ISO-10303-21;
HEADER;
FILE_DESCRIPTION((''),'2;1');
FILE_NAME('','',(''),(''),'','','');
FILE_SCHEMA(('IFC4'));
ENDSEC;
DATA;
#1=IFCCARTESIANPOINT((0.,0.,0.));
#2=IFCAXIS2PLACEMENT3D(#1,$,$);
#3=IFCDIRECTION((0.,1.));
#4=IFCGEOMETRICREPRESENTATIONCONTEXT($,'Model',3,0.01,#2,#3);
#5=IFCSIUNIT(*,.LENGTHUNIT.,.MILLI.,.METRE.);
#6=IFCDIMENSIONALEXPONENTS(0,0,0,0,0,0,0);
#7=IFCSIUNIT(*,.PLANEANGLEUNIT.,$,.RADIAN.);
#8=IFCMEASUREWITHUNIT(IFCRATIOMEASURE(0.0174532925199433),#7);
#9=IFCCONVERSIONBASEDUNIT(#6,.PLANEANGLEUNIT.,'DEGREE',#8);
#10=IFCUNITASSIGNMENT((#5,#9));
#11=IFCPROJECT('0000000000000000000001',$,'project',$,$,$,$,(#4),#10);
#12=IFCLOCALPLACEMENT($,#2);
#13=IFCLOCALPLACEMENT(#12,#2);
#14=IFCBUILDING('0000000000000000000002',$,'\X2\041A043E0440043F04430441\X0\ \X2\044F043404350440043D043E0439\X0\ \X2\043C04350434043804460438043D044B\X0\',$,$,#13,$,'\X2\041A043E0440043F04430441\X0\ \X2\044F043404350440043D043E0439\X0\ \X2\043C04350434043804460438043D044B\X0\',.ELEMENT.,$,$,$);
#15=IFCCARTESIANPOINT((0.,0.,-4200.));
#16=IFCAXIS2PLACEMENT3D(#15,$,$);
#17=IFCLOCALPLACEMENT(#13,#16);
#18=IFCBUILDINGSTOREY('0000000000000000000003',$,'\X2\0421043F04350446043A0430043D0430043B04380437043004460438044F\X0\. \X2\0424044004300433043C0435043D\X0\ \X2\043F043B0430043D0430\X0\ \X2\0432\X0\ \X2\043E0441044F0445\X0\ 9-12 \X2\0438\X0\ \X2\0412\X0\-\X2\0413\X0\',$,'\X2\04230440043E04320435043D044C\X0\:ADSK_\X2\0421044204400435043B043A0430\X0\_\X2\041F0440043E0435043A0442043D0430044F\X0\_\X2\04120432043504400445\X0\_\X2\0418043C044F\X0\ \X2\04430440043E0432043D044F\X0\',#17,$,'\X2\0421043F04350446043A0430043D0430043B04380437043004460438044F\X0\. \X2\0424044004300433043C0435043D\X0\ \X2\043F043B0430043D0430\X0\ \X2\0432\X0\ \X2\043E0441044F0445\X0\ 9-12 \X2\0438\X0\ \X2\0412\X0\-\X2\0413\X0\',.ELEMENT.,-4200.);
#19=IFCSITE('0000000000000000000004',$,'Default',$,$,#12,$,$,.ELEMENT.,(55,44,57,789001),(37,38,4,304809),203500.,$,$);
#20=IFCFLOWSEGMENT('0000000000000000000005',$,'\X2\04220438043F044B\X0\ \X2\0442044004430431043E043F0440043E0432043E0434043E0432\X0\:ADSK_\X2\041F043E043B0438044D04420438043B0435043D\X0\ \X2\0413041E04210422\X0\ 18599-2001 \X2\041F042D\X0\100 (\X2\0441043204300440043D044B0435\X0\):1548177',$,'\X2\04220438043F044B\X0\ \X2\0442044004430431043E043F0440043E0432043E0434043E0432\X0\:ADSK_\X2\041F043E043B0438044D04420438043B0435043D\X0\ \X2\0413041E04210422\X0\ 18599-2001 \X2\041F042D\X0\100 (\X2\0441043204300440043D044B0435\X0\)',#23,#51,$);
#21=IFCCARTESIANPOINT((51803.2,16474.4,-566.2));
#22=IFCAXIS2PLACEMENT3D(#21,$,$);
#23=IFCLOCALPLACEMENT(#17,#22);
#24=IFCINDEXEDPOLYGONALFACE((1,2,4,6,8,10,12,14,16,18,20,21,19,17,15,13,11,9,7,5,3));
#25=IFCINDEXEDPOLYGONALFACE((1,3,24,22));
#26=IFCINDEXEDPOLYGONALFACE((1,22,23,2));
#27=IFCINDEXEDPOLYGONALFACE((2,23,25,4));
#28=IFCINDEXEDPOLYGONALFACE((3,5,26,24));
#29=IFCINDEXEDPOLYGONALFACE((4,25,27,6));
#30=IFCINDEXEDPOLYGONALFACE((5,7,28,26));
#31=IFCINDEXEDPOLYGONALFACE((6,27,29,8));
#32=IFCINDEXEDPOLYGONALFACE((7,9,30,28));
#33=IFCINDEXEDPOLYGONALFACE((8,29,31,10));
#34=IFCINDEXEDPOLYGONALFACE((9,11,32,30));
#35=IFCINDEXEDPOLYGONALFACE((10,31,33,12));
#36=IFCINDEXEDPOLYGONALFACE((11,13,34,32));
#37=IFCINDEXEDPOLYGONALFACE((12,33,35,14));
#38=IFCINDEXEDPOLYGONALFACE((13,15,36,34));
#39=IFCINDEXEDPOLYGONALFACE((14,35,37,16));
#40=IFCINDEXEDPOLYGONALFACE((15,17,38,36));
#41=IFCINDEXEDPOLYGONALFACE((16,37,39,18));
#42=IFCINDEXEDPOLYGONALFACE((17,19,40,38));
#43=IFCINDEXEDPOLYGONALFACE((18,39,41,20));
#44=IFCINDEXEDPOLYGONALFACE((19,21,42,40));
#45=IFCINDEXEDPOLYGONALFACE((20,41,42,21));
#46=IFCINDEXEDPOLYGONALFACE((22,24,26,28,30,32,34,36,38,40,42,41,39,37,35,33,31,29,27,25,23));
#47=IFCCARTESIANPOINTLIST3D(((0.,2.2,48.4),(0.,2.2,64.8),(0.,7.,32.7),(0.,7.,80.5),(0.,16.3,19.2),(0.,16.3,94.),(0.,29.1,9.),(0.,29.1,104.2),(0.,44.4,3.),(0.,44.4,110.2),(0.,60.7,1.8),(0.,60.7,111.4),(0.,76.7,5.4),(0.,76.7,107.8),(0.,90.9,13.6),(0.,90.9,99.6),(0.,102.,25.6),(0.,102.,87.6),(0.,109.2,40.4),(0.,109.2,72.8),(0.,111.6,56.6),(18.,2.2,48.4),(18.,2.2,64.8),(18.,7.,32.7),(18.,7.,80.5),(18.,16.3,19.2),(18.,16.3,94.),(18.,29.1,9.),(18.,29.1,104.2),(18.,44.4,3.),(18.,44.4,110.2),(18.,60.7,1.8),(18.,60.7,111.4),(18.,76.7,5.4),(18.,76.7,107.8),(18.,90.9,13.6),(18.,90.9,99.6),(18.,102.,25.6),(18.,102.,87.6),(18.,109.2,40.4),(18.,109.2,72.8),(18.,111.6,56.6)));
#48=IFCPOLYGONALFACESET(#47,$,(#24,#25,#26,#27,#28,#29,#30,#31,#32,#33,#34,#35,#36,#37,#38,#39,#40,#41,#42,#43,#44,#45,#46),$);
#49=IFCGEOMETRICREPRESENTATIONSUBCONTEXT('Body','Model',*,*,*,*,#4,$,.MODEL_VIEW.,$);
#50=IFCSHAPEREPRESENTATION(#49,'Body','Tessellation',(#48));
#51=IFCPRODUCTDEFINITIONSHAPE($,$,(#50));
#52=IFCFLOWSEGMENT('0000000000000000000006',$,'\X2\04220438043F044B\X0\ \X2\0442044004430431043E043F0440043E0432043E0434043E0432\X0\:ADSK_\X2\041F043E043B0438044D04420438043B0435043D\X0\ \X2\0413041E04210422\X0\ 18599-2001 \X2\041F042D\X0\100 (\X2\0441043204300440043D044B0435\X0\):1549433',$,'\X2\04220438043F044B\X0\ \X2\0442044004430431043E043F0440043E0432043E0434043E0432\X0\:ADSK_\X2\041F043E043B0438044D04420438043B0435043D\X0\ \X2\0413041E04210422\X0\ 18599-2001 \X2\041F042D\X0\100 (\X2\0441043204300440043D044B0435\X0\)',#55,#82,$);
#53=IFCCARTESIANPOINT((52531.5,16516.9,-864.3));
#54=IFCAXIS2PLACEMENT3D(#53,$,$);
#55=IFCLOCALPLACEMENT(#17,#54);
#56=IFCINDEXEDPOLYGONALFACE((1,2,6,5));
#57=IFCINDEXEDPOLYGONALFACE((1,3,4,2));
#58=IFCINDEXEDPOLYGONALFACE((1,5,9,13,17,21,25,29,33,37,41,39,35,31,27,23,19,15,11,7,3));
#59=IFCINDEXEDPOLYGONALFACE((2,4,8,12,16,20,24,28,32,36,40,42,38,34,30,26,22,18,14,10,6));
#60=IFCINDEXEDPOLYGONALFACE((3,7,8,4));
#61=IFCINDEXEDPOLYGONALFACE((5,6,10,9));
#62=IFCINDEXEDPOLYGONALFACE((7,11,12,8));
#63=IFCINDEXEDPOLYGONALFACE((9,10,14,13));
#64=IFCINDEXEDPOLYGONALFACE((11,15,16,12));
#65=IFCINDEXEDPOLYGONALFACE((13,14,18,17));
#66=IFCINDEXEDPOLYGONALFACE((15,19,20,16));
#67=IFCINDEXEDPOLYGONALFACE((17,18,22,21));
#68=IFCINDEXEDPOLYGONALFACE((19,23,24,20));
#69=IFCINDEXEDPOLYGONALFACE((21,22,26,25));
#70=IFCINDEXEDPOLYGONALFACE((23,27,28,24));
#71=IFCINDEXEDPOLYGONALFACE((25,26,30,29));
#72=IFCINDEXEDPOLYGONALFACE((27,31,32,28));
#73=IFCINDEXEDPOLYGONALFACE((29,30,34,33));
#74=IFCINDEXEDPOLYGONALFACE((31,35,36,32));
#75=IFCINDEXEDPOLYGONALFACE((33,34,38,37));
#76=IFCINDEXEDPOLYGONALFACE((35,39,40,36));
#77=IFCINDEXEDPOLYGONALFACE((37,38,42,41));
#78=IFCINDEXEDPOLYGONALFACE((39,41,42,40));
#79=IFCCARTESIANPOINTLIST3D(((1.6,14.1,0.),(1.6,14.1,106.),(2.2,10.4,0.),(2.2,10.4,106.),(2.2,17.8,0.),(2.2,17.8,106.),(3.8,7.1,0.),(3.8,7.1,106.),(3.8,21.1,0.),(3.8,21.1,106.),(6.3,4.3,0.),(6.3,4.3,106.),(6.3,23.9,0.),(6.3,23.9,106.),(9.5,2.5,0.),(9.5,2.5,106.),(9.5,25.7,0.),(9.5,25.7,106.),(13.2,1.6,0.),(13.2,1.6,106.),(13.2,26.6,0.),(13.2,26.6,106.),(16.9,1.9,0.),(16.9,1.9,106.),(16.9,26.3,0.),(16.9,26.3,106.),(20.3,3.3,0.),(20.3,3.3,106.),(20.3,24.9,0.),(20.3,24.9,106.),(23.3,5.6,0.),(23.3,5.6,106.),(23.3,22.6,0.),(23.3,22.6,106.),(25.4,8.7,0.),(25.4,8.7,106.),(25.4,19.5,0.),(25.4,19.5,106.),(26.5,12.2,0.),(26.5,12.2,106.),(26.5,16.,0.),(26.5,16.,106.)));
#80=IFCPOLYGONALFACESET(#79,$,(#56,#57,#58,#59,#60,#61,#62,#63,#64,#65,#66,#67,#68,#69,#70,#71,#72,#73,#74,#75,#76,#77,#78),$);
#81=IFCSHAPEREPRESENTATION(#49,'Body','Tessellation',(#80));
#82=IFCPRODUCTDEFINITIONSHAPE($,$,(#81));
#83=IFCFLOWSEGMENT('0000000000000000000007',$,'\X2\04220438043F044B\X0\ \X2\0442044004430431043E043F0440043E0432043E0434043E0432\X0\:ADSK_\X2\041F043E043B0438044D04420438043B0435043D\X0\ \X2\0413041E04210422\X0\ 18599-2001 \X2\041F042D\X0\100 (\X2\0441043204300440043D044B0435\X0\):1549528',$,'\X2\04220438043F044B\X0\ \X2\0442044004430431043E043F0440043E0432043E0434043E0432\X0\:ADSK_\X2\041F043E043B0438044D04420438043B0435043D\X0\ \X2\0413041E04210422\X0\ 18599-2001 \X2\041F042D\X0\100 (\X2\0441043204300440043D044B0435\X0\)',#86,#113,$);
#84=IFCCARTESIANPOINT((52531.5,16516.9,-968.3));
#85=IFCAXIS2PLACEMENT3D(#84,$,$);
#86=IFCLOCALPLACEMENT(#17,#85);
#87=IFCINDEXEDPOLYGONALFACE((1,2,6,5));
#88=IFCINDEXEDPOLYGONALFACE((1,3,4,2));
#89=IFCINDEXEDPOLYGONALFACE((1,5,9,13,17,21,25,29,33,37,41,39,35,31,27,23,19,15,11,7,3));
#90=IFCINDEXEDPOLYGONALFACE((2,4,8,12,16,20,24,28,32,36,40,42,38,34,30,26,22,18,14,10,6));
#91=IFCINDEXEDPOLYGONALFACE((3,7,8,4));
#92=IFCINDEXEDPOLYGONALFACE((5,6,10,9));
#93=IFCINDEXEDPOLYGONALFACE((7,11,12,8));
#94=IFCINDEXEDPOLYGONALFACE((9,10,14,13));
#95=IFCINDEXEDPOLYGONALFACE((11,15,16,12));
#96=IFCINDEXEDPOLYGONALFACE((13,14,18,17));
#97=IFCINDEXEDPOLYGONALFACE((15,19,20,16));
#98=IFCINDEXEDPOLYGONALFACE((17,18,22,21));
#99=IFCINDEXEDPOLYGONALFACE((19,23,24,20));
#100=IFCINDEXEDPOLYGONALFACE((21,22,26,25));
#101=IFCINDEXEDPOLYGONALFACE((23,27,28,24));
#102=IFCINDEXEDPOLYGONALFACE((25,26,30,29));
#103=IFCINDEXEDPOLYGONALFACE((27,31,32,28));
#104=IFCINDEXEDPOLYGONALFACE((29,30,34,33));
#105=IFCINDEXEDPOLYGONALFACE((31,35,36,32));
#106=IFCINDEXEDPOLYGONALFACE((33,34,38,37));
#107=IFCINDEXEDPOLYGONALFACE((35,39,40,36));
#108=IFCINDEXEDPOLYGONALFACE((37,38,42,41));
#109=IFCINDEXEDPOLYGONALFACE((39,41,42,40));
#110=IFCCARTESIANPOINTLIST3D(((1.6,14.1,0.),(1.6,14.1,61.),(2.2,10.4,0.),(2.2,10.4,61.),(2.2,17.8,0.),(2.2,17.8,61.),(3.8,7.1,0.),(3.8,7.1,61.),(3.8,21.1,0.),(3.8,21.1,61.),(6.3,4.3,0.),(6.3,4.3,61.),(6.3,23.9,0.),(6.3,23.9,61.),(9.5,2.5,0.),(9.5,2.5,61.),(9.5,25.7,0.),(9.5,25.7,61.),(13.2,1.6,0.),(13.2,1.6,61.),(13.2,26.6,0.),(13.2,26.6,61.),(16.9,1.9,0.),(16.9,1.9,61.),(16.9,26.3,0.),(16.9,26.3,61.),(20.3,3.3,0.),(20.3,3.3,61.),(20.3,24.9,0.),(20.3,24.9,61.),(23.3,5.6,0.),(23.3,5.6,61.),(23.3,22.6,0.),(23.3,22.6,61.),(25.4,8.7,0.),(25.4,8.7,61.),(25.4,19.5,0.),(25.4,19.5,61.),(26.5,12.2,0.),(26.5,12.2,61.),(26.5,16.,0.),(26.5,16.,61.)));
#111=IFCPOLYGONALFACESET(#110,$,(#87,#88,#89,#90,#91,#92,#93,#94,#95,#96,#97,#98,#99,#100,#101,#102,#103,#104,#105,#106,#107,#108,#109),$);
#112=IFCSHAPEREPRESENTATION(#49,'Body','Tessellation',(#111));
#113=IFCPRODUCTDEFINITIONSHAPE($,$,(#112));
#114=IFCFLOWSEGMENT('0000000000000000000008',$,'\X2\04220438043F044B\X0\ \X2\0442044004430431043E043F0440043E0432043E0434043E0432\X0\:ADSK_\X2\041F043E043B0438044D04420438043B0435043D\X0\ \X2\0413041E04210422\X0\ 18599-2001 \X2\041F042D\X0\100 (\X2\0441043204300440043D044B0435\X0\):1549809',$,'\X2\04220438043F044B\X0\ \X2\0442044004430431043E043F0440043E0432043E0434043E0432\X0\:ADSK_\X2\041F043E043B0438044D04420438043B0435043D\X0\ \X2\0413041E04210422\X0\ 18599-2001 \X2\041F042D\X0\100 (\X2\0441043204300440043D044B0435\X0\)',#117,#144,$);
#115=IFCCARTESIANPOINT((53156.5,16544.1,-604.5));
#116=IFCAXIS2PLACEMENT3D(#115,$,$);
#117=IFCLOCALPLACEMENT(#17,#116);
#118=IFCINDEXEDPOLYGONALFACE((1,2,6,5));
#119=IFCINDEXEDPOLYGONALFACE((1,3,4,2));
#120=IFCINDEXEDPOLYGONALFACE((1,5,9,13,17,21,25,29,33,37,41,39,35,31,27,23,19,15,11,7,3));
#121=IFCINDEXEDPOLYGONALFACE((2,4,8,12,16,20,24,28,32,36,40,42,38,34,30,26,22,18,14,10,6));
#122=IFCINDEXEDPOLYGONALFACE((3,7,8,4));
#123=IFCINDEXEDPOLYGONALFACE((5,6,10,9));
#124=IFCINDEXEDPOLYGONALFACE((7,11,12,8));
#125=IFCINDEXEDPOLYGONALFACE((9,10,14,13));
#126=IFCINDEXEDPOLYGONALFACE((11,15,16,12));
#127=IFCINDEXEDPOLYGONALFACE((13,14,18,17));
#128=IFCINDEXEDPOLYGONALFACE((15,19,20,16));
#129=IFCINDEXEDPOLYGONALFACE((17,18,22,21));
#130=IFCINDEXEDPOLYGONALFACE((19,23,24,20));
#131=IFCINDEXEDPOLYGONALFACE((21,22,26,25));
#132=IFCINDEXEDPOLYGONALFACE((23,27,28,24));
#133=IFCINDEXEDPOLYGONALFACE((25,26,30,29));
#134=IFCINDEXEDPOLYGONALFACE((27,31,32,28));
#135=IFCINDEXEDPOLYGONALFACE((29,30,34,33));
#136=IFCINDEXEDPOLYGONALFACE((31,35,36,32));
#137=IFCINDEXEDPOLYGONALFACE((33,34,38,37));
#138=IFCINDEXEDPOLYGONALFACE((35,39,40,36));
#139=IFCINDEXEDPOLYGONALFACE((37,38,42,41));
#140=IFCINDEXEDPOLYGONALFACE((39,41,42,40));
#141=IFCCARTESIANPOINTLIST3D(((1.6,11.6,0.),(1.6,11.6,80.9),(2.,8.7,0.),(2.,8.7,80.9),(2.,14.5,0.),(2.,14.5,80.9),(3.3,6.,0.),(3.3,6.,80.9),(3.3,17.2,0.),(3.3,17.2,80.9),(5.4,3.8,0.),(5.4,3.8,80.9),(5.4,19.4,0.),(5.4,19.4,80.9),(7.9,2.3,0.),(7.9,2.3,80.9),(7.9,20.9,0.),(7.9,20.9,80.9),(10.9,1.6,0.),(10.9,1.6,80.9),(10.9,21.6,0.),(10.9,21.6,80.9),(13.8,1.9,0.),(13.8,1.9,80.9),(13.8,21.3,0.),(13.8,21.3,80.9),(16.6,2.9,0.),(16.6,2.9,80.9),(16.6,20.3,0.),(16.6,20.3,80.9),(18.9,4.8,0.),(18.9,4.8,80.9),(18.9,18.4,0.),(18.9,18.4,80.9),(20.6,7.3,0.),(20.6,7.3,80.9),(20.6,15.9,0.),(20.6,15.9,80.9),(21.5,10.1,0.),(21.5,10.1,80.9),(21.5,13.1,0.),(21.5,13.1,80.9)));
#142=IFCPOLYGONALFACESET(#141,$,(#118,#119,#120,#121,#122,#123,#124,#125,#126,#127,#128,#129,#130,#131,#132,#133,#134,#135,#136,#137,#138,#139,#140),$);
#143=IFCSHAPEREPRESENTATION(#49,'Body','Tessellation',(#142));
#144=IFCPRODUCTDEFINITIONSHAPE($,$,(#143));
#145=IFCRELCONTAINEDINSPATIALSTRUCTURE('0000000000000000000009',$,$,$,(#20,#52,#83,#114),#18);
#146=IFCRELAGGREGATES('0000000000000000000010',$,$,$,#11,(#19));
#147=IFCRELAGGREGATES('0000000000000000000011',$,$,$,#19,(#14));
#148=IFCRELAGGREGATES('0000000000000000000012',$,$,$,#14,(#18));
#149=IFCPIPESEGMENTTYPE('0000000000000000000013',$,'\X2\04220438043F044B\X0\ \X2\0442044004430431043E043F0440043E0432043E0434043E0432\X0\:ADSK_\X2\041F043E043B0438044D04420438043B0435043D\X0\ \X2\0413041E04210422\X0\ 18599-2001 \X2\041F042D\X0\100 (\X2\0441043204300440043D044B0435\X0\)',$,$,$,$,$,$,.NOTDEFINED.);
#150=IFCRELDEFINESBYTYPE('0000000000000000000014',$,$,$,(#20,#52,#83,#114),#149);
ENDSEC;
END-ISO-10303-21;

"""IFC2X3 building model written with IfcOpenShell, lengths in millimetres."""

from ifc_helpers import new_model, entity, si_unit, converted_unit, direction, frame, origin, origin_2d_with_axis, place, context, subcontext, project, spatial, circle, extrude, type_object, element, save


model = new_model("IFC2X3")

# Units and contexts
model_context = context("Model", 3, precision=0.01, world=origin(), true_north=direction((0.0, 1.0)))
body_context = subcontext(model_context, "Body", "Model", "MODEL_VIEW")
ifc_project = project(units=[si_unit("LENGTHUNIT", "METRE", prefix="MILLI"), converted_unit("PLANEANGLEUNIT", "DEGREE", entity("IfcRatioMeasure", 0.0174532925199433), si_unit("PLANEANGLEUNIT", "RADIAN"), dimensions=[0, 0, 0, 0, 0, 0, 0])], contexts=[model_context])

# Site, building, storey
site_placement = place(None, origin())
site = spatial("IfcSite", under=ifc_project, at=site_placement, Name="Default", CompositionType="ELEMENT", RefLatitude=(55, 44, 57, 789001), RefLongitude=(37, 38, 4, 304809), RefElevation=203500.0)
building_placement = place(site_placement, origin())
building = spatial("IfcBuilding", under=site, at=building_placement, Name="Корпус ядерной медицины", LongName="Корпус ядерной медицины", CompositionType="ELEMENT")
storey_placement = place(building_placement, frame((0.0, 0.0, -4200.0)))
storey = spatial("IfcBuildingStorey", under=building, at=storey_placement, Name="Спецканализация. Фрагмен плана в осях 9-12 и В-Г", ObjectType="Уровень:ADSK_Стрелка_Проектная_Вверх_Имя уровня", LongName="Спецканализация. Фрагмен плана в осях 9-12 и В-Г", CompositionType="ELEMENT", Elevation=-4200.0)

# Flow segments
pipe_segment_type = type_object("IfcPipeSegmentType", Name="Типы трубопроводов:ADSK_Полиэтилен ГОСТ 18599-2001 ПЭ100 (сварные)", PredefinedType="NOTDEFINED")
flow_segment_1_placement = place(storey_placement, frame((51803.2, 16474.4, -566.2)))
element("IfcFlowSegment", 1, at=flow_segment_1_placement, inside=storey, type_object=pipe_segment_type, Name="Типы трубопроводов:ADSK_Полиэтилен ГОСТ 18599-2001 ПЭ100 (сварные):1548177", ObjectType="Типы трубопроводов:ADSK_Полиэтилен ГОСТ 18599-2001 ПЭ100 (сварные)", context=body_context, shape_type="SweptSolid", body=[
    extrude(circle(Radius=55.0, at=origin_2d_with_axis()), frame((0.0, 56.6, 56.6), z_axis=(1.0, 0.0, 0.0), x_axis=(0.0, 1.0, 0.0)), (0.0, 0.0, 1.0), 18.0),
])
flow_segment_2_placement = place(storey_placement, frame((52531.5, 16516.9, -864.3)))
element("IfcFlowSegment", 2, at=flow_segment_2_placement, inside=storey, type_object=pipe_segment_type, Name="Типы трубопроводов:ADSK_Полиэтилен ГОСТ 18599-2001 ПЭ100 (сварные):1549433", ObjectType="Типы трубопроводов:ADSK_Полиэтилен ГОСТ 18599-2001 ПЭ100 (сварные)", context=body_context, shape_type="SweptSolid", body=[
    extrude(circle(Radius=12.5, at=origin_2d_with_axis()), frame((14.1, 14.1, 0.0), z_axis=(0.0, 0.0, 1.0), x_axis=(-1.0, 0.0, 0.0)), (0.0, 0.0, 1.0), 106.0),
])
flow_segment_3_placement = place(storey_placement, frame((52531.5, 16516.9, -968.3)))
element("IfcFlowSegment", 3, at=flow_segment_3_placement, inside=storey, type_object=pipe_segment_type, Name="Типы трубопроводов:ADSK_Полиэтилен ГОСТ 18599-2001 ПЭ100 (сварные):1549528", ObjectType="Типы трубопроводов:ADSK_Полиэтилен ГОСТ 18599-2001 ПЭ100 (сварные)", context=body_context, shape_type="SweptSolid", body=[
    extrude(circle(Radius=12.5, at=origin_2d_with_axis()), frame((14.1, 14.1, 0.0), z_axis=(0.0, 0.0, 1.0), x_axis=(-1.0, 0.0, 0.0)), (0.0, 0.0, 1.0), 61.0),
])
flow_segment_4_placement = place(storey_placement, frame((53156.5, 16544.1, -604.5)))
element("IfcFlowSegment", 4, at=flow_segment_4_placement, inside=storey, type_object=pipe_segment_type, Name="Типы трубопроводов:ADSK_Полиэтилен ГОСТ 18599-2001 ПЭ100 (сварные):1549809", ObjectType="Типы трубопроводов:ADSK_Полиэтилен ГОСТ 18599-2001 ПЭ100 (сварные)", context=body_context, shape_type="SweptSolid", body=[
    extrude(circle(Radius=10.0, at=origin_2d_with_axis()), frame((11.6, 11.6, 0.0), z_axis=(0.0, 0.0, 1.0), x_axis=(-1.0, 0.0, 0.0)), (0.0, 0.0, 1.0), 80.9),
])

save(model, "model.ifc")
